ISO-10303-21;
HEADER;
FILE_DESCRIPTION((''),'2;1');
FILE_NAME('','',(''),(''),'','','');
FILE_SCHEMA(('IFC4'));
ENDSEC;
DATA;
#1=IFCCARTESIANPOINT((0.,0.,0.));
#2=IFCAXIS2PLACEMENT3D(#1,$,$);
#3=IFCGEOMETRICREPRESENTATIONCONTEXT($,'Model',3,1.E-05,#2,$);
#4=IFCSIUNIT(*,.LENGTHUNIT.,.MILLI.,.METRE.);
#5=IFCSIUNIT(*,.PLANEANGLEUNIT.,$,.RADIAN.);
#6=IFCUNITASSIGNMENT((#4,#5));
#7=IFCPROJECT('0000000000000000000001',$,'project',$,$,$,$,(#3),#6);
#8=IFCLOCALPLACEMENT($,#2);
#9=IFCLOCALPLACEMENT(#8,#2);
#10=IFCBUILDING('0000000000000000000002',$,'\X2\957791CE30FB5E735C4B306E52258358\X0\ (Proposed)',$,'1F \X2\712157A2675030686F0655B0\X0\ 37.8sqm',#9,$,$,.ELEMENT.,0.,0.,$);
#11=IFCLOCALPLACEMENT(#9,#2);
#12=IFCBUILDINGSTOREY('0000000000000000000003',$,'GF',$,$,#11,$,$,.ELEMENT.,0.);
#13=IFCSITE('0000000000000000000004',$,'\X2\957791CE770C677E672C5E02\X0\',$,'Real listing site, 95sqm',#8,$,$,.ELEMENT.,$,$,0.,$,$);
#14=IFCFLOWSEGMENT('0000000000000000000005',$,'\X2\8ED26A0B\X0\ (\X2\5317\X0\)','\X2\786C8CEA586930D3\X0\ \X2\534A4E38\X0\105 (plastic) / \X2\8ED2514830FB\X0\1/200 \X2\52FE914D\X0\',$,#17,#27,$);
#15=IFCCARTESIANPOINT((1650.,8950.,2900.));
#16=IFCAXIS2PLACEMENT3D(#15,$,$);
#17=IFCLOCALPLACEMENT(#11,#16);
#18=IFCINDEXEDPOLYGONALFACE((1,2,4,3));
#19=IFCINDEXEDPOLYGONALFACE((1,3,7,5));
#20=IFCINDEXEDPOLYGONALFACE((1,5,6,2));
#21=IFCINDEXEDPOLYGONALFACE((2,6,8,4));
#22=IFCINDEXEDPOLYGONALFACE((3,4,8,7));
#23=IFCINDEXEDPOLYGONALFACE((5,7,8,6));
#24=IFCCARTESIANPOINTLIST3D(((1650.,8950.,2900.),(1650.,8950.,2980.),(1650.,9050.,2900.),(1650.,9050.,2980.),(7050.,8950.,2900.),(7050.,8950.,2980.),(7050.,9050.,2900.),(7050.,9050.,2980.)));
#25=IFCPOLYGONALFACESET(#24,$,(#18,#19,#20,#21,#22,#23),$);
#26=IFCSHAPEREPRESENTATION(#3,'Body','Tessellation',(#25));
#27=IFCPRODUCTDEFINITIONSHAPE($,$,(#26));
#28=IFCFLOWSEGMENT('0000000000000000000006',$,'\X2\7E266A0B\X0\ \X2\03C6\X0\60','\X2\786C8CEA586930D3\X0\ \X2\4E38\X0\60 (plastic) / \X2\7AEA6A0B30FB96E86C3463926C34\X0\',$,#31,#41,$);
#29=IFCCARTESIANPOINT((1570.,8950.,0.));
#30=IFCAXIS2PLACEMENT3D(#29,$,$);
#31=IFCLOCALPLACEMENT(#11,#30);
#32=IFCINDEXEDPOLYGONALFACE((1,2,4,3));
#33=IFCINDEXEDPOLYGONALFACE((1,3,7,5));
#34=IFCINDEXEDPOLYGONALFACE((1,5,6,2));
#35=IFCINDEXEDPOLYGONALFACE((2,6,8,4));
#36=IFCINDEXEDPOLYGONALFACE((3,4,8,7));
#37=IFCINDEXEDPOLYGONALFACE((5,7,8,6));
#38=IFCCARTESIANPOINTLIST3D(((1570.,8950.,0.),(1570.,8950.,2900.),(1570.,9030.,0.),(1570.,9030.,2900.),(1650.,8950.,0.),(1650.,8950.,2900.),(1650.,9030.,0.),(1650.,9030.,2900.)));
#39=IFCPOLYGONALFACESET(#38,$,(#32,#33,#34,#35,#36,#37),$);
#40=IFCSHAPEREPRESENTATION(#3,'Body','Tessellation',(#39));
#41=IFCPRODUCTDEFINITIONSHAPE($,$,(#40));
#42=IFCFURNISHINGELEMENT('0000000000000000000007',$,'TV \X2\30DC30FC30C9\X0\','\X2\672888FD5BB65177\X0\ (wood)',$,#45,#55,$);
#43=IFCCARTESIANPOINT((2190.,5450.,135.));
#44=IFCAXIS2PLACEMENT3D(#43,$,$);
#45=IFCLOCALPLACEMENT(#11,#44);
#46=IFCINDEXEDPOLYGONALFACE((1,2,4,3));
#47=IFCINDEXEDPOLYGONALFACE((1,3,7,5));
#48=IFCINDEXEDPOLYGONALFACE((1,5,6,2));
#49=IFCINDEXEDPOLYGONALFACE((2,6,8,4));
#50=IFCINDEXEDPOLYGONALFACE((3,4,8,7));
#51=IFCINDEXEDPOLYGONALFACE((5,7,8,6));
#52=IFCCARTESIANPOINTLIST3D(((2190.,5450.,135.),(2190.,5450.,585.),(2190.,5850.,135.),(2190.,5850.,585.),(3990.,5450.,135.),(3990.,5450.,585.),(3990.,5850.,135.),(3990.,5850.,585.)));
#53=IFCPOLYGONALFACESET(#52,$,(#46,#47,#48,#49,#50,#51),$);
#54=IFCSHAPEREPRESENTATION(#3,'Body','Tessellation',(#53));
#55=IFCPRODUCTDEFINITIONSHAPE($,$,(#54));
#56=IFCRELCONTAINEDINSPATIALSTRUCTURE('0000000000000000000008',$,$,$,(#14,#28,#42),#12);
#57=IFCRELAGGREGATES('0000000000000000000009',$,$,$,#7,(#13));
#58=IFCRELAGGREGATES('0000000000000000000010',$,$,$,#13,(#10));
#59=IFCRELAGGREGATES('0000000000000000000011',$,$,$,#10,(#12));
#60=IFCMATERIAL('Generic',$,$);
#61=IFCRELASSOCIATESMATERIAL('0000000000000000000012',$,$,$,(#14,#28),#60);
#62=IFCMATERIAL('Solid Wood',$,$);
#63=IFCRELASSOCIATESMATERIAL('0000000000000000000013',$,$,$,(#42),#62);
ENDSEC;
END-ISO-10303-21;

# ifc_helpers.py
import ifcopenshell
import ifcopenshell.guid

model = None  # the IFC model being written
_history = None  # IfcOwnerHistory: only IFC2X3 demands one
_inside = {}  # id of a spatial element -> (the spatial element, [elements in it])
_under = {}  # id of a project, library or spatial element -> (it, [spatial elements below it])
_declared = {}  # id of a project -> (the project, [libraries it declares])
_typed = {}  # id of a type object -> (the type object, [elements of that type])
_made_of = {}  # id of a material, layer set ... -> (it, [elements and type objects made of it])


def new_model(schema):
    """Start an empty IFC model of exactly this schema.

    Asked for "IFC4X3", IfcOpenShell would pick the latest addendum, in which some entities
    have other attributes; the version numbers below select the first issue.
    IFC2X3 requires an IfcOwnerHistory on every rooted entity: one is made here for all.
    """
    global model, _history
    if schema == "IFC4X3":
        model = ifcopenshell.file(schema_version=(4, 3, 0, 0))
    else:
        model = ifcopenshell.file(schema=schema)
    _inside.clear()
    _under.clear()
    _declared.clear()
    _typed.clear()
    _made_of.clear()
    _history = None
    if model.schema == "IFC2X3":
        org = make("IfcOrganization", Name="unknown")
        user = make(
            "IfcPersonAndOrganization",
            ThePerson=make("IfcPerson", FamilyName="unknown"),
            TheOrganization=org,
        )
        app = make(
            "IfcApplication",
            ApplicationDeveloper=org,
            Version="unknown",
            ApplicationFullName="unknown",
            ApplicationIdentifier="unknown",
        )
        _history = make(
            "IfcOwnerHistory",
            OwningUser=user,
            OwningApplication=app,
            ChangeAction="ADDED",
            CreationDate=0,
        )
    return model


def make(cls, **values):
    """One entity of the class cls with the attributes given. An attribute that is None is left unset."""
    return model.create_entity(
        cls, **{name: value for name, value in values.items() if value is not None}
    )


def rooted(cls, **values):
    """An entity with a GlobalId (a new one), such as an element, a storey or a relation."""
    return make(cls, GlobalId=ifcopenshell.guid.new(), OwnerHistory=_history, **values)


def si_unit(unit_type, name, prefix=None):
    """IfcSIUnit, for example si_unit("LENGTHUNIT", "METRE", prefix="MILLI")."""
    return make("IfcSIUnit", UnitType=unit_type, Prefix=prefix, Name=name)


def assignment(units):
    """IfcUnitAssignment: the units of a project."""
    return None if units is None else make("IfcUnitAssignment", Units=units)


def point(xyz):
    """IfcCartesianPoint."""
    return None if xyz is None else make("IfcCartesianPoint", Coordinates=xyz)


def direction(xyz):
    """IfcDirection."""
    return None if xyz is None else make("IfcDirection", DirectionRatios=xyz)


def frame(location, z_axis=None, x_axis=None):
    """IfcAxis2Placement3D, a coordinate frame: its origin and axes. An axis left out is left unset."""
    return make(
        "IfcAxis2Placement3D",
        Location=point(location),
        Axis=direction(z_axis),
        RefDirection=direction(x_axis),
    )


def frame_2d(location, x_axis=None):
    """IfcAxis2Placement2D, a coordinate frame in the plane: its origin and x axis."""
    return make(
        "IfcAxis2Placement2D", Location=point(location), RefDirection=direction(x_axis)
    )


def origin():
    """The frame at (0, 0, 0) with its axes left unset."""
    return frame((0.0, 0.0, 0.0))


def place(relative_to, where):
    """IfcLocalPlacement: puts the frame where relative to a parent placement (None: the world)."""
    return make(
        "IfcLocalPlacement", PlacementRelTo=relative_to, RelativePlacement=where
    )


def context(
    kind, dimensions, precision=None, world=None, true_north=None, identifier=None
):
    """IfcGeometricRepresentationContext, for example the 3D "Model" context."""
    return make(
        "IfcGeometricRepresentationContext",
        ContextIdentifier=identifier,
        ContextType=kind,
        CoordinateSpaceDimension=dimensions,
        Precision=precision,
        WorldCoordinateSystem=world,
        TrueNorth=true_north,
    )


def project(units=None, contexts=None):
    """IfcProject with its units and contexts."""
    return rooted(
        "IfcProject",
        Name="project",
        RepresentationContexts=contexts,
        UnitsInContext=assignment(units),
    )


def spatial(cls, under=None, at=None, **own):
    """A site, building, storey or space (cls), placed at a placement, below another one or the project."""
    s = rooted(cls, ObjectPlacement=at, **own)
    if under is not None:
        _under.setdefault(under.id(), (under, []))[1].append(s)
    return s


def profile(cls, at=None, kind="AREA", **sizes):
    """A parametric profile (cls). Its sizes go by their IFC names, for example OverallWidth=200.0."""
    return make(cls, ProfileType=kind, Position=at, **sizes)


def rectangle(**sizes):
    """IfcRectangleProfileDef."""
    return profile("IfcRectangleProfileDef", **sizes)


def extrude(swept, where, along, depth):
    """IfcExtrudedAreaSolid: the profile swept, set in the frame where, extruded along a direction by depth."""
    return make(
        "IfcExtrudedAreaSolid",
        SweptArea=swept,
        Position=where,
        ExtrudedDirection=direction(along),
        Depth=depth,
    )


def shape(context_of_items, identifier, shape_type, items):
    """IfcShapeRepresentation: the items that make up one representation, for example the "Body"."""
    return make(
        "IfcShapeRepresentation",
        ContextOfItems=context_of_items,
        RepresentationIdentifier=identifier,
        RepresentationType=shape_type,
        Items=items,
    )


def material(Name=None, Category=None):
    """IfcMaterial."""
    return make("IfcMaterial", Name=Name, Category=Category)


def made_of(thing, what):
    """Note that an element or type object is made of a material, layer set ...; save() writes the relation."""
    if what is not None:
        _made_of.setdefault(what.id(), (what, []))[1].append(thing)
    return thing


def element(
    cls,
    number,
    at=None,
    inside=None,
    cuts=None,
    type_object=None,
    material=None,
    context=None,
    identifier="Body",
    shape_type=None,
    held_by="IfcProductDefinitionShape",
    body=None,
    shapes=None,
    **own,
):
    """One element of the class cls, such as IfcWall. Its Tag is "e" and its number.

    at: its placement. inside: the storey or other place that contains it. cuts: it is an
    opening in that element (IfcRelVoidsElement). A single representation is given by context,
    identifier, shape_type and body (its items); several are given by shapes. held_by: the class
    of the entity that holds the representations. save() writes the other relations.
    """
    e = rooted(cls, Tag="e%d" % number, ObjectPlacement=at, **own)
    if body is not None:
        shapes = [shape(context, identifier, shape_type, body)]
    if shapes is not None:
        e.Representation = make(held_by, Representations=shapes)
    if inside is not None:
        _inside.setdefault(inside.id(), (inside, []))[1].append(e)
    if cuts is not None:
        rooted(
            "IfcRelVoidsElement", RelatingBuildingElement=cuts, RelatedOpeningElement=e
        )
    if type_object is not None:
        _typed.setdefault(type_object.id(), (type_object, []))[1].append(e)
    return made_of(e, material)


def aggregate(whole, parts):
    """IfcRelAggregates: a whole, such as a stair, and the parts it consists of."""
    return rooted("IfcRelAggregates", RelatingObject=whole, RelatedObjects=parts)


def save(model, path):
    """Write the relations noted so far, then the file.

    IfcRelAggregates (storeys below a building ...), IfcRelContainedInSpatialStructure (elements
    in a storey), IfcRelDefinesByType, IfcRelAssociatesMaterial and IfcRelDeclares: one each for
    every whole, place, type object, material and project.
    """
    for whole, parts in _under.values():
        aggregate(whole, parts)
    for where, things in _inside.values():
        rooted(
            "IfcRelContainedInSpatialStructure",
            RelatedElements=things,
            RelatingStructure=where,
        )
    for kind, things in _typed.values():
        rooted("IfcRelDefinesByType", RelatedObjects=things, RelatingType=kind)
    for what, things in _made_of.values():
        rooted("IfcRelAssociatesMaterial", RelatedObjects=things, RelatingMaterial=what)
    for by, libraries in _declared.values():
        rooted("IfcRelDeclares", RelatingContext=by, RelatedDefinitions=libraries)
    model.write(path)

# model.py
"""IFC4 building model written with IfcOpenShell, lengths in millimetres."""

from ifc_helpers import new_model, si_unit, frame, frame_2d, origin, place, context, project, spatial, rectangle, extrude, material, element, save


model = new_model("IFC4")

# Units and contexts
model_context = context("Model", 3, precision=1e-05, world=origin())
ifc_project = project(units=[si_unit("LENGTHUNIT", "METRE", prefix="MILLI"), si_unit("PLANEANGLEUNIT", "RADIAN")], contexts=[model_context])

# Site, building, storey
site_placement = place(None, origin())
site = spatial("IfcSite", under=ifc_project, at=site_placement, Name="長野県松本市", ObjectType="Real listing site, 95sqm", CompositionType="ELEMENT", RefElevation=0.0)
building_placement = place(site_placement, origin())
building = spatial("IfcBuilding", under=site, at=building_placement, Name="長野・平屋の別荘 (Proposed)", ObjectType="1F 無垢材と漆喰 37.8sqm", CompositionType="ELEMENT", ElevationOfRefHeight=0.0, ElevationOfTerrain=0.0)
storey_placement = place(building_placement, origin())
storey = spatial("IfcBuildingStorey", under=building, at=storey_placement, Name="GF", CompositionType="ELEMENT", Elevation=0.0)

# Shared definitions
ifc_material_1 = material(Name="Solid Wood")

# Shared definitions
ifc_material_2 = material(Name="Generic")

# Flow segments
flow_segment_1_placement = place(storey_placement, frame((1650.0, 8950.0, 2900.0)))
element("IfcFlowSegment", 1, at=flow_segment_1_placement, inside=storey, material=ifc_material_2, Name="軒樋 (北)", Description="硬質塩ビ 半丸105 (plastic) / 軒先・1/200 勾配", context=model_context, shape_type="SweptSolid", body=[
    extrude(rectangle(XDim=5400.0, YDim=100.0, at=frame_2d((2700.0, 50.0))), frame((1650.0, 8950.0, 2900.0)), (0.0, 0.0, 1.0), 80.0),
])
flow_segment_2_placement = place(storey_placement, frame((1570.0, 8950.0, 0.0)))
element("IfcFlowSegment", 2, at=flow_segment_2_placement, inside=storey, material=ifc_material_2, Name="縦樋 φ60", Description="硬質塩ビ 丸60 (plastic) / 竪樋・雨水排水", context=model_context, shape_type="SweptSolid", body=[
    extrude(rectangle(XDim=80.0, YDim=80.0, at=frame_2d((40.0, 40.0))), frame((1570.0, 8950.0, 0.0)), (0.0, 0.0, 1.0), 2900.0),
])

# Furnishing element
furnishing_placement = place(storey_placement, frame((2190.0, 5450.0, 135.0)))
element("IfcFurnishingElement", 3, at=furnishing_placement, inside=storey, material=ifc_material_1, Name="TV ボード", Description="木製家具 (wood)", context=model_context, shape_type="SweptSolid", body=[
    extrude(rectangle(XDim=1800.0, YDim=400.0, at=frame_2d((900.0, 200.0))), frame((2190.0, 5450.0, 135.0)), (0.0, 0.0, 1.0), 450.0),
])

save(model, "model.ifc")
